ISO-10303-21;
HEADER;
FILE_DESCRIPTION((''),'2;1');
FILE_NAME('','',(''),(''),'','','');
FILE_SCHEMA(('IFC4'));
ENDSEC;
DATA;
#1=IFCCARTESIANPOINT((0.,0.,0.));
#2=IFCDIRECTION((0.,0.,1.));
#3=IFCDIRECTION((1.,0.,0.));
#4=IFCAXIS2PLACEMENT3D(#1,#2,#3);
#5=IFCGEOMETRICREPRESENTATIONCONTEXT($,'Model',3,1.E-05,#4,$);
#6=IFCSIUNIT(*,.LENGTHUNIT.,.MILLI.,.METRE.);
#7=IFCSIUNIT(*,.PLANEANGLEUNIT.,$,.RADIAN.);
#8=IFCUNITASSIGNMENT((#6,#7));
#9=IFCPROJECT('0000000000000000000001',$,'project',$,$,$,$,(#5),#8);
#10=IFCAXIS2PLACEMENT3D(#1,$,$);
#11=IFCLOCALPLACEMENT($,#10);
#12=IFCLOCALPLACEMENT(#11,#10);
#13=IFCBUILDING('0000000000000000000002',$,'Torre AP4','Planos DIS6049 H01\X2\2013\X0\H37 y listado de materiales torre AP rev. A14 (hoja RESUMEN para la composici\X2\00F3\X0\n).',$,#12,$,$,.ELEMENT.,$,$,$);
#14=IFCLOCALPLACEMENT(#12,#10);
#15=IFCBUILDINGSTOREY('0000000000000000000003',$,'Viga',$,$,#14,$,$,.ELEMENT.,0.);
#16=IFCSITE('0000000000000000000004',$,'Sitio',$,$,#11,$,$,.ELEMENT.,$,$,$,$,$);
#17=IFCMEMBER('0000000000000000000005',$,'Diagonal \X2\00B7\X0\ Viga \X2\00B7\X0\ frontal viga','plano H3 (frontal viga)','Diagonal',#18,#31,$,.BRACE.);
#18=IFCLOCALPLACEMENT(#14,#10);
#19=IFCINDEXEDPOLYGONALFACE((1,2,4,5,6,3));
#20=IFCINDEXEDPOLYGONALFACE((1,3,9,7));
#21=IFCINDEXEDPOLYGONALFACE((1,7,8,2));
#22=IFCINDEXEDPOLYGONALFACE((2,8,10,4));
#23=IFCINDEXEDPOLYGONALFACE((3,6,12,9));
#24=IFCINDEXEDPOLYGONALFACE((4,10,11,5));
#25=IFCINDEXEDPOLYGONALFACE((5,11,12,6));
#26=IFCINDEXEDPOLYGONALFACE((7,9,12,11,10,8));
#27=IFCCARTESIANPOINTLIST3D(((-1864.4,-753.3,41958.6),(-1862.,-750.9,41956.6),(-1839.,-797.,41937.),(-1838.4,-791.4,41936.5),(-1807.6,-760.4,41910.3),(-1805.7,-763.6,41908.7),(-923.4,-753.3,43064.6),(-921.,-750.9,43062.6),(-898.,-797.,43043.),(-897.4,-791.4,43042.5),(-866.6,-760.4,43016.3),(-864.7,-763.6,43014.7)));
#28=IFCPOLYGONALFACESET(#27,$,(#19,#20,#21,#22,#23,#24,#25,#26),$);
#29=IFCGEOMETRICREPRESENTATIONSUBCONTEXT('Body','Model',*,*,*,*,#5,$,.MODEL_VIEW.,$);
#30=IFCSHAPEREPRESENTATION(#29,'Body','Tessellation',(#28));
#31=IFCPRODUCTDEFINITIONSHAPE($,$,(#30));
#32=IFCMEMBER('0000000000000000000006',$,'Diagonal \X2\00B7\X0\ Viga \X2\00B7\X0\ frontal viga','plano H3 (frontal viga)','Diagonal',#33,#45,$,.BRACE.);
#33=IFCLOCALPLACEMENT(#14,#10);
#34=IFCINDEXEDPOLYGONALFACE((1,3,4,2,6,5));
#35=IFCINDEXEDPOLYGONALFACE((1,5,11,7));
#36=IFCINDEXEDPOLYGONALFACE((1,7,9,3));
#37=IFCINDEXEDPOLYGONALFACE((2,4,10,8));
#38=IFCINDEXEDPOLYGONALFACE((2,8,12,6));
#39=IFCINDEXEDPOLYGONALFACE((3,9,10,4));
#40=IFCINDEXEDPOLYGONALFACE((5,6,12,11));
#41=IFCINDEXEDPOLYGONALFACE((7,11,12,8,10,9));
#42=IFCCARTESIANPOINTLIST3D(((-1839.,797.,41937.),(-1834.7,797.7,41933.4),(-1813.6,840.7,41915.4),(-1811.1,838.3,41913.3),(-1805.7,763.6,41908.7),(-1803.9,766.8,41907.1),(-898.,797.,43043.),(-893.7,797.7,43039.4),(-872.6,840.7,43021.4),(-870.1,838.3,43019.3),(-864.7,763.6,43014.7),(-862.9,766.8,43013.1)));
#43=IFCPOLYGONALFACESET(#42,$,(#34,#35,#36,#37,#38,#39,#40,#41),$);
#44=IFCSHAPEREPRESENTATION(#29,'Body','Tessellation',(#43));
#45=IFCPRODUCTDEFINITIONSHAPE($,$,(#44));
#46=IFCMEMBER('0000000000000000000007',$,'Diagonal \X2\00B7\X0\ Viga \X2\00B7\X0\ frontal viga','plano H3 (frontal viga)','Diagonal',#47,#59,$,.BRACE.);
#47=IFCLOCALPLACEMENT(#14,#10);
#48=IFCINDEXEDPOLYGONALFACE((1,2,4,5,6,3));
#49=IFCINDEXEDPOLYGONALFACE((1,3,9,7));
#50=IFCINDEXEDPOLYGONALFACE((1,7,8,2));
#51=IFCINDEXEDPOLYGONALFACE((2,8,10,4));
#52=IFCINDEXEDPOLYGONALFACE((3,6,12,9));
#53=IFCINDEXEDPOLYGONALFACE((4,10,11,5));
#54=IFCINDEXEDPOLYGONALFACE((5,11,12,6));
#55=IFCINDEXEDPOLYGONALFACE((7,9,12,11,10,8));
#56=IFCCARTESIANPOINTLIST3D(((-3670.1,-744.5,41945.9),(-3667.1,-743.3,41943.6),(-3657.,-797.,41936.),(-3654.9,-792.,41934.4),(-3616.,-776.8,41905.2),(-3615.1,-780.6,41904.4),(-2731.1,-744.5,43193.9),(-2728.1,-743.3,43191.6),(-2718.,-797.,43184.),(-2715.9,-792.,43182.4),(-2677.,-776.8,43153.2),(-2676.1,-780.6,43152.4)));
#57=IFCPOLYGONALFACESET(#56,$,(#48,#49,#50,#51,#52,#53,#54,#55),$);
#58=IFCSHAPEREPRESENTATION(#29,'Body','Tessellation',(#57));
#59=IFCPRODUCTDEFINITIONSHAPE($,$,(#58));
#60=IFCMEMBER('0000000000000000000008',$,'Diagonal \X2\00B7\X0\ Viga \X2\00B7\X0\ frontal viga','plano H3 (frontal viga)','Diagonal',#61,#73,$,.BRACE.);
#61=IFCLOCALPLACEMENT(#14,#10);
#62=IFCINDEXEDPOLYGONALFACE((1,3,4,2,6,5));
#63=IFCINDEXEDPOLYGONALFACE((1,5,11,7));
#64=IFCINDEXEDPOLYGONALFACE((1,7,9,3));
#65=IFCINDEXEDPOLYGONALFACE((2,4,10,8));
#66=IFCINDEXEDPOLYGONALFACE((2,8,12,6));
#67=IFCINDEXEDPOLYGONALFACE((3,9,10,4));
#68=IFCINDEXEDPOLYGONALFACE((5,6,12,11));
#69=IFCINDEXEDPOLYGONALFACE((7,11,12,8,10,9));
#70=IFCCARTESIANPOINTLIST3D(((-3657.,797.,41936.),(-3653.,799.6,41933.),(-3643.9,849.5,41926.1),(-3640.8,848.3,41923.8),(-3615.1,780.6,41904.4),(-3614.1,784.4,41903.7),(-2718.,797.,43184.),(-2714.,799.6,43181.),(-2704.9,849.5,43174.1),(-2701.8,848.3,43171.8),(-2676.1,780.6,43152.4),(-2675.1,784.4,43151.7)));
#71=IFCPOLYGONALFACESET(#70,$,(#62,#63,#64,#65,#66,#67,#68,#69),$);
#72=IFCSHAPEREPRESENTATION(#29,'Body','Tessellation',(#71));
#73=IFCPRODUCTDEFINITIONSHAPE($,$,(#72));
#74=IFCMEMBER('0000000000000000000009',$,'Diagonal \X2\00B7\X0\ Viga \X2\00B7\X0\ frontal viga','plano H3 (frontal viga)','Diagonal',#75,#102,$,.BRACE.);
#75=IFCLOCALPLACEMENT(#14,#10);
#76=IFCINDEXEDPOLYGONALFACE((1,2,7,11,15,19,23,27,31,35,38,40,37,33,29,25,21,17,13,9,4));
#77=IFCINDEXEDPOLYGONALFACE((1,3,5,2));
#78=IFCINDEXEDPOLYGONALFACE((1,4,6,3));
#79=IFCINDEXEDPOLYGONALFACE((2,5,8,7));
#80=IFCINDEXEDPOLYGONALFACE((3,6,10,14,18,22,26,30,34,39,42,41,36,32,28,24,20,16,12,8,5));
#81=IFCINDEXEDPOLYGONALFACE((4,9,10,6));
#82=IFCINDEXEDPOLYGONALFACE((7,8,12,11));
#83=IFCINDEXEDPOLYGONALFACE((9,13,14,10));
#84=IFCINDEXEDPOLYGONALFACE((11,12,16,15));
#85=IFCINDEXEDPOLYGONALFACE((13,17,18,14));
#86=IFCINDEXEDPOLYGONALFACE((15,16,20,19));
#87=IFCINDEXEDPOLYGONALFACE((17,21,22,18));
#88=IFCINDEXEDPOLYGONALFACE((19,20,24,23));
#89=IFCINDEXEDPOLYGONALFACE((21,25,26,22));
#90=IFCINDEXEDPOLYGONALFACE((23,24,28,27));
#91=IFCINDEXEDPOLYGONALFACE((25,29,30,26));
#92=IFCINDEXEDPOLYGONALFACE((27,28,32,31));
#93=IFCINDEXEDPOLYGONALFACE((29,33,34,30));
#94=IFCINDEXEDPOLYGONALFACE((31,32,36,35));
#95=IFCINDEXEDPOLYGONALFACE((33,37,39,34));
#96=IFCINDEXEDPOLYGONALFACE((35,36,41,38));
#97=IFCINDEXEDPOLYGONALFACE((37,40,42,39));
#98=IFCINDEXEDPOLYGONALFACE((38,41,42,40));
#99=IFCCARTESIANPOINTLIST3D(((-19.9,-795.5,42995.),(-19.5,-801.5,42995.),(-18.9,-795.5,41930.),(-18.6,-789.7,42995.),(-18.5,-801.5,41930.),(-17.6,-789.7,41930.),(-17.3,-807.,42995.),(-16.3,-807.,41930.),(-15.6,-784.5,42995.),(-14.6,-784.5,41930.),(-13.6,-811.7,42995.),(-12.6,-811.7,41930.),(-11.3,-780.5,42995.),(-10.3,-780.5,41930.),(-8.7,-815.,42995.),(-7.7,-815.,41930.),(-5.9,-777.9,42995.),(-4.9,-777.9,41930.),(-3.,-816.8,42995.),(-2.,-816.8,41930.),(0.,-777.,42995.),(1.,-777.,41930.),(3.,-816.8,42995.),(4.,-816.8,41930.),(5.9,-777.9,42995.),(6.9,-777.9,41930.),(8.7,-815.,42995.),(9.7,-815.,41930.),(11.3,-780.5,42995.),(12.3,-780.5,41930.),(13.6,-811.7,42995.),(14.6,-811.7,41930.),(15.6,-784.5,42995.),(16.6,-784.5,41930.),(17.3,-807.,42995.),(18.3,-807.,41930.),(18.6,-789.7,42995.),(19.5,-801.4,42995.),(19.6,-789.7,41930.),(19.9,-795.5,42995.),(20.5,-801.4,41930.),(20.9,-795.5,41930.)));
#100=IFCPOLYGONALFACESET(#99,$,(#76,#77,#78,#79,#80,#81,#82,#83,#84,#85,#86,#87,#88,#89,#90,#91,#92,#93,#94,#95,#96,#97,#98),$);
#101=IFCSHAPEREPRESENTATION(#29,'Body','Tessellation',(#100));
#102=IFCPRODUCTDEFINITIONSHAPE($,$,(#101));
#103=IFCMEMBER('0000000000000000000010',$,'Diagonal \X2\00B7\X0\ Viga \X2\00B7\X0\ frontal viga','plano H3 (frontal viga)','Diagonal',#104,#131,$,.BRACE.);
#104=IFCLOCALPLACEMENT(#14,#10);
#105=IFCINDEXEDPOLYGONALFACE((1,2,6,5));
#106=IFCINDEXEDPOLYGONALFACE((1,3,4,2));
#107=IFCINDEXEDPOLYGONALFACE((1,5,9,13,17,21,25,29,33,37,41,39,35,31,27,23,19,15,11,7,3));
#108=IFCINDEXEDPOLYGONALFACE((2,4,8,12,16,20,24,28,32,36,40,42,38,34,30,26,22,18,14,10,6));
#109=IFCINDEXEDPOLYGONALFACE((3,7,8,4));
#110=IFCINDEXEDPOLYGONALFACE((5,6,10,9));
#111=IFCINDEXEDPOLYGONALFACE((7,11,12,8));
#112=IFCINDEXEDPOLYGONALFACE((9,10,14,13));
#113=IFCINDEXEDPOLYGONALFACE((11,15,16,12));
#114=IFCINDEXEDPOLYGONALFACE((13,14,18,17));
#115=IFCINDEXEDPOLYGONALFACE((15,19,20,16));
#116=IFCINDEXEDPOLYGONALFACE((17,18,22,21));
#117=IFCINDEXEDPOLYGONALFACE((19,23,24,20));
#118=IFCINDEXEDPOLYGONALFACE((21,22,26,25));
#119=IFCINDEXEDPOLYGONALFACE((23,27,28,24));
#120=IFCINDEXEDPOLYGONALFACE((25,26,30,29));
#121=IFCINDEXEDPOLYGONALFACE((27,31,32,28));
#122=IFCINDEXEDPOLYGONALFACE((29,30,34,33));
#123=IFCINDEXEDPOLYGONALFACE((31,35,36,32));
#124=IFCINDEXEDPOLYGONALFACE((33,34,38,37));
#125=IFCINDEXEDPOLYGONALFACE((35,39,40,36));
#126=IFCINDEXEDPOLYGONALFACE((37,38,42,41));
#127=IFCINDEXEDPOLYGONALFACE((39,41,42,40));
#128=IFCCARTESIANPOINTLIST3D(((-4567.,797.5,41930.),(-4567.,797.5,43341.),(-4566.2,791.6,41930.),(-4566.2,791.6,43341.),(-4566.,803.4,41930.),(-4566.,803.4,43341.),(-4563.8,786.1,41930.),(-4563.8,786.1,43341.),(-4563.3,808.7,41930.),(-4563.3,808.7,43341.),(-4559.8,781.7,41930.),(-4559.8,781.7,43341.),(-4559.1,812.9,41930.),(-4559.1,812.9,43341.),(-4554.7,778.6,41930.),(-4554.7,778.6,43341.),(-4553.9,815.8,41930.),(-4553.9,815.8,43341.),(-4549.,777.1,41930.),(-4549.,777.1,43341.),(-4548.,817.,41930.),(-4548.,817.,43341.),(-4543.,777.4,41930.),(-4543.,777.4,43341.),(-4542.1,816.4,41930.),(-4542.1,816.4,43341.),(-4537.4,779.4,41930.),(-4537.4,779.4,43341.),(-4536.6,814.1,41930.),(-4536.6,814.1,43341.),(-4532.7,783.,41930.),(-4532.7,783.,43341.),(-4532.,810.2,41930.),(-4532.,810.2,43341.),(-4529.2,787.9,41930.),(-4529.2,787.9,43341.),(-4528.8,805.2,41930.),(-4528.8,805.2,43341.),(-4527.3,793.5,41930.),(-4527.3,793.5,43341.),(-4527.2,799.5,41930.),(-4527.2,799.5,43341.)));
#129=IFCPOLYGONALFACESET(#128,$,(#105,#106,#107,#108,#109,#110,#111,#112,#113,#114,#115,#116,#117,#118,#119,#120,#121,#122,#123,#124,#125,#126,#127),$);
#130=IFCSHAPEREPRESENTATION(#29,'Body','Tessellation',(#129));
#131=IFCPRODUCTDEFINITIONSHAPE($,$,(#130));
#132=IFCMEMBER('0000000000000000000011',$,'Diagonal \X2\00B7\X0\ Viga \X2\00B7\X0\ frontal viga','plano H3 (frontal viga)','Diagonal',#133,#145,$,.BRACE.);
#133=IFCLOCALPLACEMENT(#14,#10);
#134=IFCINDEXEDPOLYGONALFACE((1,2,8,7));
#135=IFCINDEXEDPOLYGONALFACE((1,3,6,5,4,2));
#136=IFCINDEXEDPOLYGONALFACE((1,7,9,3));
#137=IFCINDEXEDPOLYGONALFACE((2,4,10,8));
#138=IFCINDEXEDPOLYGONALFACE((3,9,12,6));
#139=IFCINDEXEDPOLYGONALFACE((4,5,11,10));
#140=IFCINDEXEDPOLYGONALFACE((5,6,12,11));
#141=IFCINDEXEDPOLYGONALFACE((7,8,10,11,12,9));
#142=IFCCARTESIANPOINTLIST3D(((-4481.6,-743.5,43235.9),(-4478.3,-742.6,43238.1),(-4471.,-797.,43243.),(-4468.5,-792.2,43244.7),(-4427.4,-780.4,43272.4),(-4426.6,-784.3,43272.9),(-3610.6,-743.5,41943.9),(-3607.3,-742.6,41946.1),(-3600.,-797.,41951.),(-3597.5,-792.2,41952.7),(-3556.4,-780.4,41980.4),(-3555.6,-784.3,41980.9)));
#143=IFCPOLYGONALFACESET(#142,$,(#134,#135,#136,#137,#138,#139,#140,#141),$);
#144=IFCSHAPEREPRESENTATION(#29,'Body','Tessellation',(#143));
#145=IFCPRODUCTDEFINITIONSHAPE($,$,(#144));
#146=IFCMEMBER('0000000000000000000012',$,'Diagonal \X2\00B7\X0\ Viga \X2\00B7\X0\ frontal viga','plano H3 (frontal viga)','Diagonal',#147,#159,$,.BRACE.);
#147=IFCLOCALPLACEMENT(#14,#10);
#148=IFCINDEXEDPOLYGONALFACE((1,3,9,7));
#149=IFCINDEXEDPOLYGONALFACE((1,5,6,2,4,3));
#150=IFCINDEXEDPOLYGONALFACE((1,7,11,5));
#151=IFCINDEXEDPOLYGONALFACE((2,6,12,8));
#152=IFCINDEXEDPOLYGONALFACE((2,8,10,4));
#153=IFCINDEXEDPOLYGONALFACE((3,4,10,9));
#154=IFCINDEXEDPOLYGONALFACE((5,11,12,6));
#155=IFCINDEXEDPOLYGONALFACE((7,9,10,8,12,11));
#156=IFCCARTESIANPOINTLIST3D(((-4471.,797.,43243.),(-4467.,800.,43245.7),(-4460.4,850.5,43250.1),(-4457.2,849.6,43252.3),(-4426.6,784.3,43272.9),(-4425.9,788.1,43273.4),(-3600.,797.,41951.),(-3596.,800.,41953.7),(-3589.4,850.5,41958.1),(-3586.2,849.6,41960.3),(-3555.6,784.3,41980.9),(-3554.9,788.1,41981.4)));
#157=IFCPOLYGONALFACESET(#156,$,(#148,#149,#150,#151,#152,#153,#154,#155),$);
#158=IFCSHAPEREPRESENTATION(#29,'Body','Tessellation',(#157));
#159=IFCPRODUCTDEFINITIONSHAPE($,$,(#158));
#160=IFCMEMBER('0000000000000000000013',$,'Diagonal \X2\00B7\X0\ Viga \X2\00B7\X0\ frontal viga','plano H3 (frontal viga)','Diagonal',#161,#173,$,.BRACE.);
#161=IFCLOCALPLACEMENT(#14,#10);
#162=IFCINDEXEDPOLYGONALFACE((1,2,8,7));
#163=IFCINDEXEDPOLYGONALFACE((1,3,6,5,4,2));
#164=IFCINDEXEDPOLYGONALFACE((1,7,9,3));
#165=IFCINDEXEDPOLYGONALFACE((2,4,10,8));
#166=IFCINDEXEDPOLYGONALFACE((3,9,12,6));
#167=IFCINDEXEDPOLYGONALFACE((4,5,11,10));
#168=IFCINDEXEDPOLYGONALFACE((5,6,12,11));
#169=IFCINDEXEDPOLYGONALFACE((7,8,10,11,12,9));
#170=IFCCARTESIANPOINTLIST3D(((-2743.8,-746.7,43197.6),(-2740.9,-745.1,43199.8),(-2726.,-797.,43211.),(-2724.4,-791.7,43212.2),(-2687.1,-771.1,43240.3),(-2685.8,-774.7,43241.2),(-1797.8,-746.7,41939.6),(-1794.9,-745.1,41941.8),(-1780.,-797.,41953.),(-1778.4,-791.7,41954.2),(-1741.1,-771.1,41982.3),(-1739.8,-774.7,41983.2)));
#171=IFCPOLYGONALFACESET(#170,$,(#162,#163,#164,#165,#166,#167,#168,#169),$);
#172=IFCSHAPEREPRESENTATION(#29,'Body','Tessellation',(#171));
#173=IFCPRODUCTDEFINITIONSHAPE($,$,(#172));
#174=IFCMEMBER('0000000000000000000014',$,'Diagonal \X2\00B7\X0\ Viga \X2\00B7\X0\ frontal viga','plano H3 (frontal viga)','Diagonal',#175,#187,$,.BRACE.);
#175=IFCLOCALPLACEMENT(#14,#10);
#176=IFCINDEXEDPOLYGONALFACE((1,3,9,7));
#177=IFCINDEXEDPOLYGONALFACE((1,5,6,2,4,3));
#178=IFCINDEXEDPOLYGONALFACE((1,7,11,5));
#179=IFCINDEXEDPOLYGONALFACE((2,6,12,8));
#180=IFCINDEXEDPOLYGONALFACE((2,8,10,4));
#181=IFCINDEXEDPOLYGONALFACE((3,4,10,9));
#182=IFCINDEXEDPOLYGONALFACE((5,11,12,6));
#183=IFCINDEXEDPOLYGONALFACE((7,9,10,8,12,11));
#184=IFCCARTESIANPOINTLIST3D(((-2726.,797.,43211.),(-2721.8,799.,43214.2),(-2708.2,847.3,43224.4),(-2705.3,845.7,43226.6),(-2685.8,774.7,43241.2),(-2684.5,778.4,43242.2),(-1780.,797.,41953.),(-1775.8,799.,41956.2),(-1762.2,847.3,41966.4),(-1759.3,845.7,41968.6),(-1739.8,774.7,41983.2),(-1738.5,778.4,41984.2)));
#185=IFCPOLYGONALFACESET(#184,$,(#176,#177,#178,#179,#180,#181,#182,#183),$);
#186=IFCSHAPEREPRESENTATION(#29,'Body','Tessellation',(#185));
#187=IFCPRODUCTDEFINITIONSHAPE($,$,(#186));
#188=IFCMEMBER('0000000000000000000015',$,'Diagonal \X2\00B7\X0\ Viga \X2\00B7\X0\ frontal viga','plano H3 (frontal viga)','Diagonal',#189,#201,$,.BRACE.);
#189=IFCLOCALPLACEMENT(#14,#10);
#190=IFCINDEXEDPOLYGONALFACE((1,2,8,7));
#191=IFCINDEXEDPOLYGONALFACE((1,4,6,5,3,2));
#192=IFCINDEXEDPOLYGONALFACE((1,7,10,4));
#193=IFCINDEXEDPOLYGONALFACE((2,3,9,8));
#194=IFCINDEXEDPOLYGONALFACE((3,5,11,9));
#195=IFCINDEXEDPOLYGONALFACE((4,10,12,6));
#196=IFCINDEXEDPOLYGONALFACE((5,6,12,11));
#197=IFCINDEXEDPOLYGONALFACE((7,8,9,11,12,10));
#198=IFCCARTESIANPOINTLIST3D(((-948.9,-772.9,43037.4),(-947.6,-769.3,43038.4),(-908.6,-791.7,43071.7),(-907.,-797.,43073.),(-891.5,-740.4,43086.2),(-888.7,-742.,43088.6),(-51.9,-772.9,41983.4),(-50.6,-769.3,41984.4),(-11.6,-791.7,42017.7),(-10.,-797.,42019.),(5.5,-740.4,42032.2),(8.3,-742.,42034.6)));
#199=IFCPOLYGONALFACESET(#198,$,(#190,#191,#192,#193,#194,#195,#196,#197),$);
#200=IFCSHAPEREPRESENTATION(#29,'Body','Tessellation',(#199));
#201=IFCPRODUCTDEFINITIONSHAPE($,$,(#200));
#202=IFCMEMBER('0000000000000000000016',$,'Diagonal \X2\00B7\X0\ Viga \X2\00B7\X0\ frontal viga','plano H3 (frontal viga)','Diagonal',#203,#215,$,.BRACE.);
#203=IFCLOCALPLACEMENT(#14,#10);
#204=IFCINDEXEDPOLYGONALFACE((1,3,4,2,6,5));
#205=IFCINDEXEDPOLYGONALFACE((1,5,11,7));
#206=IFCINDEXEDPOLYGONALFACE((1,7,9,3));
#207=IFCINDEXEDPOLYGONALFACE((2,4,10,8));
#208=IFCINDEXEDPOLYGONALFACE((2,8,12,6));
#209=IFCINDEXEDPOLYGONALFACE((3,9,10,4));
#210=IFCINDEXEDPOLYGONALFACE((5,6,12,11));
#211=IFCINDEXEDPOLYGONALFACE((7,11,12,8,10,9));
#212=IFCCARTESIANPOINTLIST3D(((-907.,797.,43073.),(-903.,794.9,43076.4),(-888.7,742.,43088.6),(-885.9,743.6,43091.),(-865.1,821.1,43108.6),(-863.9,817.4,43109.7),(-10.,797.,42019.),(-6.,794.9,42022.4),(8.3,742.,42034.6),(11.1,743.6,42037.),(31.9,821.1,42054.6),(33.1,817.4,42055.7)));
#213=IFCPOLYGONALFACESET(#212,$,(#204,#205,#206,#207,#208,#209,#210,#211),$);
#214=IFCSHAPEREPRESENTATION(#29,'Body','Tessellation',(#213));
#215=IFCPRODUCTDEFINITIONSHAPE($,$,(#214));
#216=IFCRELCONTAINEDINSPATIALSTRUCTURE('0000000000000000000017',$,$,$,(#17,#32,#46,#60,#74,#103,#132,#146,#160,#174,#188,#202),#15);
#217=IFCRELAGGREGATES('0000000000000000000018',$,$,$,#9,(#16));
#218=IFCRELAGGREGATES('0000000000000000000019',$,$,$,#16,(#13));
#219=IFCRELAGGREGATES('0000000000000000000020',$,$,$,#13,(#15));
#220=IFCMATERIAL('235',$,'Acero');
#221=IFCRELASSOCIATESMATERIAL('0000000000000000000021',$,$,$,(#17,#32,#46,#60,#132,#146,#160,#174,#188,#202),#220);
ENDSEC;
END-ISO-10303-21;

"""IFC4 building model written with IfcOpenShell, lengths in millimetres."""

from ifc_helpers import new_model, si_unit, frame, frame_2d, origin, origin_with_axes, place, context, subcontext, project, spatial, circle, l_section, extrude, material, element, save


model = new_model("IFC4")

# Units and contexts
model_context = context("Model", 3, precision=1e-05, world=origin_with_axes())
body_context = subcontext(model_context, "Body", "Model", "MODEL_VIEW")
ifc_project = project(units=[si_unit("LENGTHUNIT", "METRE", prefix="MILLI"), si_unit("PLANEANGLEUNIT", "RADIAN")], contexts=[model_context])

# Site, building, storey
site_placement = place(None, origin())
site = spatial("IfcSite", under=ifc_project, at=site_placement, Name="Sitio", CompositionType="ELEMENT")
building_placement = place(site_placement, origin())
building = spatial("IfcBuilding", under=site, at=building_placement, Name="Torre AP4", Description="Planos DIS6049 H01–H37 y listado de materiales torre AP rev. A14 (hoja RESUMEN para la composición).", CompositionType="ELEMENT")
storey_placement = place(building_placement, origin())
storey = spatial("IfcBuildingStorey", under=building, at=storey_placement, Name="Viga", CompositionType="ELEMENT", Elevation=0.0)

# Members
ifc_material = material(Name="235", Category="Acero")
for number, where, z_axis, x_axis, name in (
    (1, (-1839.0, -797.0, 41937.0), (0.648008, 0.0, 0.761633), (0.605023, 0.607426, -0.514762), "Diagonal · Viga · frontal viga"),
    (2, (-1839.0, 797.0, 41937.0), (0.648008, 0.0, 0.761633), (0.605023, -0.607426, -0.514762), "Diagonal · Viga · frontal viga"),
):
    element("IfcMember", number, at=place(storey_placement, frame(where, z_axis=z_axis, x_axis=x_axis)), inside=storey, material=ifc_material, Name=name, Description="plano H3 (frontal viga)", ObjectType="Diagonal", PredefinedType="BRACE", context=body_context, shape_type="SweptSolid", body=[
        extrude(l_section(Depth=55.0, Width=55.0, Thickness=4.0, at=frame_2d((27.5, 27.5))), None, (0.0, 0.0, 1.0), 1452.1),
    ])
for number, where, z_axis, x_axis, name in (
    (3, (-3657.0, -797.0, 41936.0), (0.601229, 0.0, 0.799077), (0.762614, 0.298631, -0.573794), "Diagonal · Viga · frontal viga"),
    (4, (-3657.0, 797.0, 41936.0), (0.601229, 0.0, 0.799077), (0.762614, -0.298631, -0.573794), "Diagonal · Viga · frontal viga"),
):
    element("IfcMember", number, at=place(storey_placement, frame(where, z_axis=z_axis, x_axis=x_axis)), inside=storey, material=ifc_material, Name=name, Description="plano H3 (frontal viga)", ObjectType="Diagonal", PredefinedType="BRACE", context=body_context, shape_type="SweptSolid", body=[
        extrude(l_section(Depth=55.0, Width=55.0, Thickness=4.0, at=frame_2d((27.5, 27.5))), None, (0.0, 0.0, 1.0), 1561.8),
    ])
member_1_placement = place(storey_placement, frame((1.0, -797.0, 41930.0), z_axis=(-0.000939, 0.0, 1.0), x_axis=(-0.000627, 1.0, -0.000001)))
element("IfcMember", 5, at=member_1_placement, inside=storey, Name="Diagonal · Viga · frontal viga", Description="plano H3 (frontal viga)", ObjectType="Diagonal", PredefinedType="BRACE", context=body_context, shape_type="SweptSolid", body=[
    extrude(circle(Radius=20.0), None, (0.0, 0.0, 1.0), 1065.0),
])
member_2_placement = place(storey_placement, frame((-4547.0, 797.0, 41930.0), z_axis=(0.0, 0.0, 1.0), x_axis=(0.984984, -0.172648, 0.0)))
element("IfcMember", 6, at=member_2_placement, inside=storey, Name="Diagonal · Viga · frontal viga", Description="plano H3 (frontal viga)", ObjectType="Diagonal", PredefinedType="BRACE", context=body_context, shape_type="SweptSolid", body=[
    extrude(circle(Radius=20.0), None, (0.0, 0.0, 1.0), 1411.0),
])
for number, where, z_axis, x_axis, name in (
    (7, (-3600.0, -797.0, 41951.0), (-0.558988, 0.0, 0.829176), (0.806611, 0.231703, 0.543776), "Diagonal · Viga · frontal viga"),
    (8, (-3600.0, 797.0, 41951.0), (-0.558988, 0.0, 0.829176), (0.806611, -0.231703, 0.543776), "Diagonal · Viga · frontal viga"),
):
    element("IfcMember", number, at=place(storey_placement, frame(where, z_axis=z_axis, x_axis=x_axis)), inside=storey, material=ifc_material, Name=name, Description="plano H3 (frontal viga)", ObjectType="Diagonal", PredefinedType="BRACE", context=body_context, shape_type="SweptSolid", body=[
        extrude(l_section(Depth=55.0, Width=55.0, Thickness=4.0, at=frame_2d((27.5, 27.5))), None, (0.0, 0.0, 1.0), 1558.2),
    ])
for number, where, z_axis, x_axis, name in (
    (9, (-1780.0, -797.0, 41953.0), (-0.601016, 0.0, 0.799237), (0.730849, 0.404737, 0.549589), "Diagonal · Viga · frontal viga"),
    (10, (-1780.0, 797.0, 41953.0), (-0.601016, 0.0, 0.799237), (0.730849, -0.404737, 0.549589), "Diagonal · Viga · frontal viga"),
):
    element("IfcMember", number, at=place(storey_placement, frame(where, z_axis=z_axis, x_axis=x_axis)), inside=storey, material=ifc_material, Name=name, Description="plano H3 (frontal viga)", ObjectType="Diagonal", PredefinedType="BRACE", context=body_context, shape_type="SweptSolid", body=[
        extrude(l_section(Depth=55.0, Width=55.0, Thickness=4.0, at=frame_2d((27.5, 27.5))), None, (0.0, 0.0, 1.0), 1574.0),
    ])
for number, where, z_axis, x_axis, name in (
    (11, (-10.0, -797.0, 42019.0), (-0.64811, 0.0, 0.761547), (0.305596, 0.915954, 0.260076), "Diagonal · Viga · frontal viga"),
    (12, (-10.0, 797.0, 42019.0), (-0.64811, 0.0, 0.761547), (0.305596, -0.915954, 0.260076), "Diagonal · Viga · frontal viga"),
):
    element("IfcMember", number, at=place(storey_placement, frame(where, z_axis=z_axis, x_axis=x_axis)), inside=storey, material=ifc_material, Name=name, Description="plano H3 (frontal viga)", ObjectType="Diagonal", PredefinedType="BRACE", context=body_context, shape_type="SweptSolid", body=[
        extrude(l_section(Depth=60.0, Width=60.0, Thickness=4.0, at=frame_2d((30.0, 30.0))), None, (0.0, 0.0, 1.0), 1384.0),
    ])

save(model, "model.ifc")
